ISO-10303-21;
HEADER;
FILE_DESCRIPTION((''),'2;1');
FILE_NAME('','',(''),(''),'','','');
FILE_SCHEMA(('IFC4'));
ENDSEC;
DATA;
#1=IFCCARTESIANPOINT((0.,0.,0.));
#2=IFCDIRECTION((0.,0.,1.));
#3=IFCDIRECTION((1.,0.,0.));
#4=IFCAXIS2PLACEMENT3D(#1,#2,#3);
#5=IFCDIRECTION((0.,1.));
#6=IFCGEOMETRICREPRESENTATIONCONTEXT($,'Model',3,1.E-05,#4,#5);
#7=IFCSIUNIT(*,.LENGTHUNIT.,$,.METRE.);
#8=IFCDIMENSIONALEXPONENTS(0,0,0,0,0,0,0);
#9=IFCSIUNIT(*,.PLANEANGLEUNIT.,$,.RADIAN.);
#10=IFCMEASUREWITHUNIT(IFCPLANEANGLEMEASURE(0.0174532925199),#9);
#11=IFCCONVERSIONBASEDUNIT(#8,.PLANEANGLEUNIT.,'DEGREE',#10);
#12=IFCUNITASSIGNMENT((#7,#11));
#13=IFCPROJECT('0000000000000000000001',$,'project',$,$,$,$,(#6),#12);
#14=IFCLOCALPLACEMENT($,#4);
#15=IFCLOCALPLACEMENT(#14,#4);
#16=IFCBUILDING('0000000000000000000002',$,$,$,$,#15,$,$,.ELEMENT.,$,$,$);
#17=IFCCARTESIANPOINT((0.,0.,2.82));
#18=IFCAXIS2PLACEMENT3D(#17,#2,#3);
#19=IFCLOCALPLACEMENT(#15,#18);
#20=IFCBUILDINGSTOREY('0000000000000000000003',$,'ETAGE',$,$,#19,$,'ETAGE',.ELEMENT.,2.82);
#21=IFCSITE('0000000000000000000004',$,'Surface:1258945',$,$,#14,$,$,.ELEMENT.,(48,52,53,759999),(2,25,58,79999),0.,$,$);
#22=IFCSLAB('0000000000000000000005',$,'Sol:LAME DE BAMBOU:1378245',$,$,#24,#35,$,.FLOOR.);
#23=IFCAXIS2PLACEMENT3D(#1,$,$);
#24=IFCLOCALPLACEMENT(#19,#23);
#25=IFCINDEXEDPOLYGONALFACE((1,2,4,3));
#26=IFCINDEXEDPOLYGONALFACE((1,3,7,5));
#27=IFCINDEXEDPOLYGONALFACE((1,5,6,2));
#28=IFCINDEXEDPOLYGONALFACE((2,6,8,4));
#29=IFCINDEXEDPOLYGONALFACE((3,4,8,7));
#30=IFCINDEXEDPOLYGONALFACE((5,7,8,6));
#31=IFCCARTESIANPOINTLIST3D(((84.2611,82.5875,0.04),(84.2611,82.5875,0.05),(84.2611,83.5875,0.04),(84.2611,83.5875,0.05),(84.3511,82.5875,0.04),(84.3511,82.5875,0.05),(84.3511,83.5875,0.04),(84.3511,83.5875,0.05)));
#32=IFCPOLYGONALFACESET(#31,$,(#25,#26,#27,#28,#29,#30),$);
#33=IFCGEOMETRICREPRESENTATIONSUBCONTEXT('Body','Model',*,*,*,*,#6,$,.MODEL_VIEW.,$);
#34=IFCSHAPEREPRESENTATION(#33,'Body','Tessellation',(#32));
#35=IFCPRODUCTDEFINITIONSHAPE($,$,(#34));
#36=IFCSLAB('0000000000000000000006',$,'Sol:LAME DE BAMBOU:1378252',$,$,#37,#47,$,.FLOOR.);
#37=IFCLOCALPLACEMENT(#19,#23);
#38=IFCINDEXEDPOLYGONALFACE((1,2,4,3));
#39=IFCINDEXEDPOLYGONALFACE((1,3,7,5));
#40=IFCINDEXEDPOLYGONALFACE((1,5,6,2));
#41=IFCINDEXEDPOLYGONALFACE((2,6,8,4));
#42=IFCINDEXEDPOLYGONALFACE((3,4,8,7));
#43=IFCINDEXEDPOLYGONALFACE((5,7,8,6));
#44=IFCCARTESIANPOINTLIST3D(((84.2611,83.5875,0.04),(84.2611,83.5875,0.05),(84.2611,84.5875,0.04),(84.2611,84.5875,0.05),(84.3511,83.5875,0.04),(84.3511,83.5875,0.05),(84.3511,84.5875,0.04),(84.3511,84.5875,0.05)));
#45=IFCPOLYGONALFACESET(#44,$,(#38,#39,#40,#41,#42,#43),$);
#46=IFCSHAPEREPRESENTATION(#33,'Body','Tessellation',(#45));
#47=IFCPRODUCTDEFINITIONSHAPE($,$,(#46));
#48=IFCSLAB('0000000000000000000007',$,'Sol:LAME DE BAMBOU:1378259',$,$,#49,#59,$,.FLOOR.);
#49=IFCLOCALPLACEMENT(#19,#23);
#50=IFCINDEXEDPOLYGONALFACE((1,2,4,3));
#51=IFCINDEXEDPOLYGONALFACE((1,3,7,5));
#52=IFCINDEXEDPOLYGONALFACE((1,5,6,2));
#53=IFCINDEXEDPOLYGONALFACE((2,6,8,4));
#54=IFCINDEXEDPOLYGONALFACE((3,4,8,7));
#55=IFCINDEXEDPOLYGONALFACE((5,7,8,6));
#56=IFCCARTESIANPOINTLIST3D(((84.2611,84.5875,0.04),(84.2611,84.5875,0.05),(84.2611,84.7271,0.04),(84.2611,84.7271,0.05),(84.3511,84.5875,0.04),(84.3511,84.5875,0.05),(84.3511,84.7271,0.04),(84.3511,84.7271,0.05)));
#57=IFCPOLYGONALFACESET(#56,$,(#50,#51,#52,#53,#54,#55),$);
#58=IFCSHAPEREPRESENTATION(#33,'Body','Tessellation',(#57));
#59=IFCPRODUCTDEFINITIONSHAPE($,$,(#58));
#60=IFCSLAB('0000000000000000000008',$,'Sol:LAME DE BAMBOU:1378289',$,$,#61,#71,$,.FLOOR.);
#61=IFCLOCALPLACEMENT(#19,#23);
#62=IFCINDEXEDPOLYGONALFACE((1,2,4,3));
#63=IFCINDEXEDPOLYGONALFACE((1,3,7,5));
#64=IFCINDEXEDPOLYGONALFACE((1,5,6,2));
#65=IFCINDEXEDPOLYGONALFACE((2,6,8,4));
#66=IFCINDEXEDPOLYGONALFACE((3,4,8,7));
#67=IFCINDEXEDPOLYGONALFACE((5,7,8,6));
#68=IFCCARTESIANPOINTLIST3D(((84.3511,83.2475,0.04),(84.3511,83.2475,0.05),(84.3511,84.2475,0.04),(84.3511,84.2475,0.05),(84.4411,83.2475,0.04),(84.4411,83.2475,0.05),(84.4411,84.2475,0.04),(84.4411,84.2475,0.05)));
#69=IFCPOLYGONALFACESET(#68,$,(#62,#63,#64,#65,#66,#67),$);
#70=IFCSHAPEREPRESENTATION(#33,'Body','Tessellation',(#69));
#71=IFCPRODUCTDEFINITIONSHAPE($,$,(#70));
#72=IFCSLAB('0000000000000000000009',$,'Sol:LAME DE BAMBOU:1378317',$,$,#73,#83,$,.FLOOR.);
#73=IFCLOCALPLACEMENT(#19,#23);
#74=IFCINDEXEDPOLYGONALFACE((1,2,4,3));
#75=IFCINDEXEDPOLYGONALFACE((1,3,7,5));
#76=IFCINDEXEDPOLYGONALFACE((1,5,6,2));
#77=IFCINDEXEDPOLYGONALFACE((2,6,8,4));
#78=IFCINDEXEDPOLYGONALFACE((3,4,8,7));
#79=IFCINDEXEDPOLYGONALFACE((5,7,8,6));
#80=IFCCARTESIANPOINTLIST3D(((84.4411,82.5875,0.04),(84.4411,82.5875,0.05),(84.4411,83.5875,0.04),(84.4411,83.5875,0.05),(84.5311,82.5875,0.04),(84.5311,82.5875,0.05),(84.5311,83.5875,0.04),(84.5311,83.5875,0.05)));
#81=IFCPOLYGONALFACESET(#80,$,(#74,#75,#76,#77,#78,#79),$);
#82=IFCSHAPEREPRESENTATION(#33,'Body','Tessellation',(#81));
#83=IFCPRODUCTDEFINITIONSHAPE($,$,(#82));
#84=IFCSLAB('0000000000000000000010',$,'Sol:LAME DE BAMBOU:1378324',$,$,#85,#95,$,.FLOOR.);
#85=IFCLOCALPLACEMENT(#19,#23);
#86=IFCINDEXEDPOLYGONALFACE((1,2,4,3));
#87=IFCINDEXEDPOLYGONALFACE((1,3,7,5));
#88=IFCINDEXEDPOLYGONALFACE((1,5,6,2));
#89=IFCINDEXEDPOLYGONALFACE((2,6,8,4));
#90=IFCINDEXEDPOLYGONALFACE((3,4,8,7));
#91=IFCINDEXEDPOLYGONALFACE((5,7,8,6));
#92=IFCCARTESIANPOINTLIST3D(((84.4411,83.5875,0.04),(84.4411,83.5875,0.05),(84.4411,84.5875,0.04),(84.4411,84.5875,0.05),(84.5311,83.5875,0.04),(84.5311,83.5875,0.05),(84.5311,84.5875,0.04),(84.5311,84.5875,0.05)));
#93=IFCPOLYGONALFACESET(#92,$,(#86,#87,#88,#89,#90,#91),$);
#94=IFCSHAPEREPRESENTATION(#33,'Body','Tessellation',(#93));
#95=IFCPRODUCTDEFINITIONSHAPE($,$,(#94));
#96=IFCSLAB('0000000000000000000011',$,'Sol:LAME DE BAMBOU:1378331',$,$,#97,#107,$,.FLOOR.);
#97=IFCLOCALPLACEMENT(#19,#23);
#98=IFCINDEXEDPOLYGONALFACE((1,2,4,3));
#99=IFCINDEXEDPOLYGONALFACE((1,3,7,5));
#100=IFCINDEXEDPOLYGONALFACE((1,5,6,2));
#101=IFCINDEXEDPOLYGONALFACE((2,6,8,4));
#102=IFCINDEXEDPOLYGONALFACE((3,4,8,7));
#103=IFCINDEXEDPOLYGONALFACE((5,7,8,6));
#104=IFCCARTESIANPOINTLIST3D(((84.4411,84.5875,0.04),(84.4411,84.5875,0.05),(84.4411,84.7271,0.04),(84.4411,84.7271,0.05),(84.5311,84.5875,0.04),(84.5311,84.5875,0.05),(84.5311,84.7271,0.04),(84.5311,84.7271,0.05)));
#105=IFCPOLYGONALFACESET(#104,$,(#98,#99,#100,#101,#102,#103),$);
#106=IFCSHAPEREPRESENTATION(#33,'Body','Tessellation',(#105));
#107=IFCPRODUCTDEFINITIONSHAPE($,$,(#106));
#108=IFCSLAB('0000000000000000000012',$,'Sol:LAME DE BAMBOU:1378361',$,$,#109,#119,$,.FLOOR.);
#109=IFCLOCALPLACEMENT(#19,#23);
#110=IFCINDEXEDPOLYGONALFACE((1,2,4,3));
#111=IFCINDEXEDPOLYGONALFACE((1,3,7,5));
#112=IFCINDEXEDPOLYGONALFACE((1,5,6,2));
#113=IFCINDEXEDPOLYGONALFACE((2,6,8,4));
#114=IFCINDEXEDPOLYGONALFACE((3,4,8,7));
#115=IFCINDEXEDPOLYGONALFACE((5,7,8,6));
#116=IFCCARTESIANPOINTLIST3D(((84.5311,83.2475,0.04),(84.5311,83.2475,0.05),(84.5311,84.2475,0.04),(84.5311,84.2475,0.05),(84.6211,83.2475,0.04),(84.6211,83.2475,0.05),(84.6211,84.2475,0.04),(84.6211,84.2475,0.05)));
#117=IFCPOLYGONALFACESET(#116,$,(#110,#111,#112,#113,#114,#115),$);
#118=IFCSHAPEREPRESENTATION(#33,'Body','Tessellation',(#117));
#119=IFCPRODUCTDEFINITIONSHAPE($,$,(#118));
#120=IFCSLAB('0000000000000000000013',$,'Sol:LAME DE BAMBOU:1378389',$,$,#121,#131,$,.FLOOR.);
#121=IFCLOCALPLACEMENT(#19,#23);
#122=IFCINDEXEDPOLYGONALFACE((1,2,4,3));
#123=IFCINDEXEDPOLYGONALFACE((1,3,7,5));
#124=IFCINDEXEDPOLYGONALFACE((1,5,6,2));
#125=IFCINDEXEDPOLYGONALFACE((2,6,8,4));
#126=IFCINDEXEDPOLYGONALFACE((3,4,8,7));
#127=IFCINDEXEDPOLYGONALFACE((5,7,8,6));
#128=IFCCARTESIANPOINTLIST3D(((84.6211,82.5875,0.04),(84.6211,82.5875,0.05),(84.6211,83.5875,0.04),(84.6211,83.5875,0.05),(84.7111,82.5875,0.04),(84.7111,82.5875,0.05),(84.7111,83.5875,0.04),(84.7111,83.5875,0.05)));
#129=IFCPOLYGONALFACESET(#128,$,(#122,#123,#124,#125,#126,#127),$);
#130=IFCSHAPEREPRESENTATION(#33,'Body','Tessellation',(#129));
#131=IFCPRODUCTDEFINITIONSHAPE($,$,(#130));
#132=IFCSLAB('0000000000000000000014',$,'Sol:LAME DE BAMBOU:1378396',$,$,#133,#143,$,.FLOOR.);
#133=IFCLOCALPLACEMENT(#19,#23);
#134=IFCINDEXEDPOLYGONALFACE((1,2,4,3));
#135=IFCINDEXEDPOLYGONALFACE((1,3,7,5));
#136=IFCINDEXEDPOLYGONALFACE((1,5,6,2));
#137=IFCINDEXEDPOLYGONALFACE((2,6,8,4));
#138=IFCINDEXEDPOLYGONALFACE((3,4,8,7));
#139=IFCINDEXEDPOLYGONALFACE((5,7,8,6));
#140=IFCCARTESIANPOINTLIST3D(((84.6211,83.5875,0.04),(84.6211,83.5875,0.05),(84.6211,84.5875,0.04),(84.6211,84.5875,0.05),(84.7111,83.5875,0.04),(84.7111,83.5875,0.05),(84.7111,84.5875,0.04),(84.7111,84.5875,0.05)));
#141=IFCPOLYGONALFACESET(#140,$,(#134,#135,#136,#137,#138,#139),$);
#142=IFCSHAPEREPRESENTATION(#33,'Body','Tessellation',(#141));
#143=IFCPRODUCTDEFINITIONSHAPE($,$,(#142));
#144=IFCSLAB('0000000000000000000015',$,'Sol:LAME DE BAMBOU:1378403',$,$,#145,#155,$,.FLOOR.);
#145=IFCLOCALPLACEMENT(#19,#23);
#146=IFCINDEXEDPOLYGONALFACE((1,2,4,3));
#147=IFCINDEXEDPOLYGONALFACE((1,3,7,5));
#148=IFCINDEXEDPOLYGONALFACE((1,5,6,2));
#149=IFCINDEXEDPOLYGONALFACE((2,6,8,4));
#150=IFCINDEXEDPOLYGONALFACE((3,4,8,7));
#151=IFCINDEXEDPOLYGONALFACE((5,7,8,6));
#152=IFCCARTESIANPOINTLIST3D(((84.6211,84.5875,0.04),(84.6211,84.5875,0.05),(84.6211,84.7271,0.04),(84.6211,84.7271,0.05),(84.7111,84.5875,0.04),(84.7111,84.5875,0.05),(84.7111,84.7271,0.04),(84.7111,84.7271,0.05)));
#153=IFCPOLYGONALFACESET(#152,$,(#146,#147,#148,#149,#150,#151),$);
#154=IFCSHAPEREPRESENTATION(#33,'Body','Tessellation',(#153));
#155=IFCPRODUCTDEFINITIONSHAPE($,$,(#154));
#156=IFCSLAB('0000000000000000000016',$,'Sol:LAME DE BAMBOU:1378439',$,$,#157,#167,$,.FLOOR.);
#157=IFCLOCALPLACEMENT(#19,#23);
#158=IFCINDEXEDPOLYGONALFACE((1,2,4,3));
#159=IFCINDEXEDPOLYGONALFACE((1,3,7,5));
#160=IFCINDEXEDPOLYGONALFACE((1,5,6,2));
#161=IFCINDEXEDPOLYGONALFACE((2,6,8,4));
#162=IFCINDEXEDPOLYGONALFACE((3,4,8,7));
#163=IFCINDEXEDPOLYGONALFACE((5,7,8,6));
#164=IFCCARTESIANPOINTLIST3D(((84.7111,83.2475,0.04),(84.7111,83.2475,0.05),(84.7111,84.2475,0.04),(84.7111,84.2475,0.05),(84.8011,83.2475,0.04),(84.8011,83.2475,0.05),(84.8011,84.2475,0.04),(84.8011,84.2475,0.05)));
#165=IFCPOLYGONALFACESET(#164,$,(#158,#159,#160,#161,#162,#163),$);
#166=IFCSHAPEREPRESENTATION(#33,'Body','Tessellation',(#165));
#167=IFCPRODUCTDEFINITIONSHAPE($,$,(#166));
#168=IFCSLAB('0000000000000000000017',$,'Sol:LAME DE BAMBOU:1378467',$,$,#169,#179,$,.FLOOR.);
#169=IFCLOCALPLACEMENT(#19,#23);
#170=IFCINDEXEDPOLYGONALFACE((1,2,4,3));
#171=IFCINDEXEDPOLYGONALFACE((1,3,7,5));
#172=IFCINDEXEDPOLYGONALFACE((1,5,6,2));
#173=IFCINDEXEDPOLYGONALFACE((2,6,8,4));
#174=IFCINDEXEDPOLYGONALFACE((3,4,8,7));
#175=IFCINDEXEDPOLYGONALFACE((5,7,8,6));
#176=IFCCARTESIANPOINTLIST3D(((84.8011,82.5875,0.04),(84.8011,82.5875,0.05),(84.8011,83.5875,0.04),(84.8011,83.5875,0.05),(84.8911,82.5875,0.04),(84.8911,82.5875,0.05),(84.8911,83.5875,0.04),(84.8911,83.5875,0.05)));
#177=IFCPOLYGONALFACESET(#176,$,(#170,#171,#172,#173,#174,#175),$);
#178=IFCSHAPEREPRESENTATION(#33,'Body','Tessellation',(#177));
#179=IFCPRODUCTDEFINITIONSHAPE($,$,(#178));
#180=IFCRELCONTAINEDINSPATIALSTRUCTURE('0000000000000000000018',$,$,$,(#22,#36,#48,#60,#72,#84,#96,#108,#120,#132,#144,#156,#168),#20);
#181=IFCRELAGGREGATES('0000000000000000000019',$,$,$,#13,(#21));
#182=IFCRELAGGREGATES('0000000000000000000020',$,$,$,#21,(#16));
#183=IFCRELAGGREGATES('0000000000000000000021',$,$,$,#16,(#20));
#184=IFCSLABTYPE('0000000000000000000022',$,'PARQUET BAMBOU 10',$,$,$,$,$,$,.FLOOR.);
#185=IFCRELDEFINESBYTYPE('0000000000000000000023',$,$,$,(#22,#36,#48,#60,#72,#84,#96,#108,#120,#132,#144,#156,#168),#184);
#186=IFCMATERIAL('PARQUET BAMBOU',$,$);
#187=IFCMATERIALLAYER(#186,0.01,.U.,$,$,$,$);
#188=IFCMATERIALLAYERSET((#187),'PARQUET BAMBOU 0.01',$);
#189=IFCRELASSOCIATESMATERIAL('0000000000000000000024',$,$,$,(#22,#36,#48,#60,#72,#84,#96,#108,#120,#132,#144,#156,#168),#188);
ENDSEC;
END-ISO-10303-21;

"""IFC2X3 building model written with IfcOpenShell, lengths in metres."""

from ifc_helpers import new_model, entity, si_unit, converted_unit, direction, frame, origin_with_axes, place, context, subcontext, project, spatial, polyline, outline, extrude, material, layer, layer_set, layer_usage, type_object, element, save


model = new_model("IFC2X3")

# Units and contexts
model_context = context("Model", 3, precision=1e-05, world=origin_with_axes(), true_north=direction((0.0, 1.0)))
body_context = subcontext(model_context, "Body", "Model", "MODEL_VIEW")
ifc_project = project(units=[si_unit("LENGTHUNIT", "METRE"), converted_unit("PLANEANGLEUNIT", "DEGREE", entity("IfcPlaneAngleMeasure", 0.0174532925199), si_unit("PLANEANGLEUNIT", "RADIAN"), dimensions=[0, 0, 0, 0, 0, 0, 0])], contexts=[model_context])

# Site, building, storey
site_placement = place(None, origin_with_axes())
site = spatial("IfcSite", under=ifc_project, at=site_placement, Name="Surface:1258945", CompositionType="ELEMENT", RefLatitude=(48, 52, 53, 759999), RefLongitude=(2, 25, 58, 79999), RefElevation=0.0)
building_placement = place(site_placement, origin_with_axes())
building = spatial("IfcBuilding", under=site, at=building_placement, CompositionType="ELEMENT")
storey_placement = place(building_placement, frame((0.0, 0.0, 2.82), z_axis=(0.0, 0.0, 1.0), x_axis=(1.0, 0.0, 0.0)))
storey = spatial("IfcBuildingStorey", under=building, at=storey_placement, Name="ETAGE", LongName="ETAGE", CompositionType="ELEMENT", Elevation=2.82)

# Slabs
ifc_material = material(Name="PARQUET BAMBOU")
ifc_layer = layer(ifc_material, 0.01, ventilated="UNKNOWN")
ifc_layer_set = layer_set([ifc_layer], Name="PARQUET BAMBOU 0.01")
ifc_layer_usage_1 = layer_usage(ifc_layer_set, "AXIS3", "NEGATIVE", 0.01)
slab_type = type_object("IfcSlabType", Name="PARQUET BAMBOU 10", PredefinedType="FLOOR")
slab_1_placement = place(storey_placement, frame((84.2611, 83.5875, 0.05), z_axis=(0.0, 0.0, 1.0), x_axis=(1.0, 0.0, 0.0)))
element("IfcSlab", 1, at=slab_1_placement, inside=storey, type_object=slab_type, material=ifc_layer_usage_1, Name="Sol:LAME DE BAMBOU:1378245", PredefinedType="FLOOR", context=body_context, shape_type="SweptSolid", body=[
    extrude(outline(polyline([(0.0, 0.0), (0.0, -1.0), (0.09, -1.0), (0.09, 0.0), (0.0, 0.0)])), frame((0.0, 0.0, -0.01), z_axis=(0.0, 0.0, 1.0), x_axis=(1.0, 0.0, 0.0)), (0.0, 0.0, 1.0), 0.01),
])
ifc_layer_usage_2 = layer_usage(ifc_layer_set, "AXIS3", "NEGATIVE", 0.01)
slab_2_placement = place(storey_placement, frame((84.2611, 84.5875, 0.05), z_axis=(0.0, 0.0, 1.0), x_axis=(1.0, 0.0, 0.0)))
element("IfcSlab", 2, at=slab_2_placement, inside=storey, type_object=slab_type, material=ifc_layer_usage_2, Name="Sol:LAME DE BAMBOU:1378252", PredefinedType="FLOOR", context=body_context, shape_type="SweptSolid", body=[
    extrude(outline(polyline([(0.0, 0.0), (0.0, -1.0), (0.09, -1.0), (0.09, 0.0), (0.0, 0.0)])), frame((0.0, 0.0, -0.01), z_axis=(0.0, 0.0, 1.0), x_axis=(1.0, 0.0, 0.0)), (0.0, 0.0, 1.0), 0.01),
])
ifc_layer_usage_3 = layer_usage(ifc_layer_set, "AXIS3", "NEGATIVE", 0.01)
slab_3_placement = place(storey_placement, frame((84.2611, 84.7271, 0.05), z_axis=(0.0, 0.0, 1.0), x_axis=(1.0, 0.0, 0.0)))
element("IfcSlab", 3, at=slab_3_placement, inside=storey, type_object=slab_type, material=ifc_layer_usage_3, Name="Sol:LAME DE BAMBOU:1378259", PredefinedType="FLOOR", context=body_context, shape_type="SweptSolid", body=[
    extrude(outline(polyline([(0.0, 0.0), (0.0, -0.1396), (0.09, -0.1396), (0.09, 0.0), (0.0, 0.0)])), frame((0.0, 0.0, -0.01), z_axis=(0.0, 0.0, 1.0), x_axis=(1.0, 0.0, 0.0)), (0.0, 0.0, 1.0), 0.01),
])
ifc_layer_usage_4 = layer_usage(ifc_layer_set, "AXIS3", "NEGATIVE", 0.01)
slab_4_placement = place(storey_placement, frame((84.3511, 84.2475, 0.05), z_axis=(0.0, 0.0, 1.0), x_axis=(1.0, 0.0, 0.0)))
element("IfcSlab", 4, at=slab_4_placement, inside=storey, type_object=slab_type, material=ifc_layer_usage_4, Name="Sol:LAME DE BAMBOU:1378289", PredefinedType="FLOOR", context=body_context, shape_type="SweptSolid", body=[
    extrude(outline(polyline([(0.0, 0.0), (0.0, -1.0), (0.09, -1.0), (0.09, 0.0), (0.0, 0.0)])), frame((0.0, 0.0, -0.01), z_axis=(0.0, 0.0, 1.0), x_axis=(1.0, 0.0, 0.0)), (0.0, 0.0, 1.0), 0.01),
])
ifc_layer_usage_5 = layer_usage(ifc_layer_set, "AXIS3", "NEGATIVE", 0.01)
slab_5_placement = place(storey_placement, frame((84.4411, 83.5875, 0.05), z_axis=(0.0, 0.0, 1.0), x_axis=(1.0, 0.0, 0.0)))
element("IfcSlab", 5, at=slab_5_placement, inside=storey, type_object=slab_type, material=ifc_layer_usage_5, Name="Sol:LAME DE BAMBOU:1378317", PredefinedType="FLOOR", context=body_context, shape_type="SweptSolid", body=[
    extrude(outline(polyline([(0.0, 0.0), (0.0, -1.0), (0.09, -1.0), (0.09, 0.0), (0.0, 0.0)])), frame((0.0, 0.0, -0.01), z_axis=(0.0, 0.0, 1.0), x_axis=(1.0, 0.0, 0.0)), (0.0, 0.0, 1.0), 0.01),
])
ifc_layer_usage_6 = layer_usage(ifc_layer_set, "AXIS3", "NEGATIVE", 0.01)
slab_6_placement = place(storey_placement, frame((84.4411, 84.5875, 0.05), z_axis=(0.0, 0.0, 1.0), x_axis=(1.0, 0.0, 0.0)))
element("IfcSlab", 6, at=slab_6_placement, inside=storey, type_object=slab_type, material=ifc_layer_usage_6, Name="Sol:LAME DE BAMBOU:1378324", PredefinedType="FLOOR", context=body_context, shape_type="SweptSolid", body=[
    extrude(outline(polyline([(0.0, 0.0), (0.0, -1.0), (0.09, -1.0), (0.09, 0.0), (0.0, 0.0)])), frame((0.0, 0.0, -0.01), z_axis=(0.0, 0.0, 1.0), x_axis=(1.0, 0.0, 0.0)), (0.0, 0.0, 1.0), 0.01),
])
ifc_layer_usage_7 = layer_usage(ifc_layer_set, "AXIS3", "NEGATIVE", 0.01)
slab_7_placement = place(storey_placement, frame((84.4411, 84.7271, 0.05), z_axis=(0.0, 0.0, 1.0), x_axis=(1.0, 0.0, 0.0)))
element("IfcSlab", 7, at=slab_7_placement, inside=storey, type_object=slab_type, material=ifc_layer_usage_7, Name="Sol:LAME DE BAMBOU:1378331", PredefinedType="FLOOR", context=body_context, shape_type="SweptSolid", body=[
    extrude(outline(polyline([(0.0, 0.0), (0.0, -0.1396), (0.09, -0.1396), (0.09, 0.0), (0.0, 0.0)])), frame((0.0, 0.0, -0.01), z_axis=(0.0, 0.0, 1.0), x_axis=(1.0, 0.0, 0.0)), (0.0, 0.0, 1.0), 0.01),
])
ifc_layer_usage_8 = layer_usage(ifc_layer_set, "AXIS3", "NEGATIVE", 0.01)
slab_8_placement = place(storey_placement, frame((84.5311, 84.2475, 0.05), z_axis=(0.0, 0.0, 1.0), x_axis=(1.0, 0.0, 0.0)))
element("IfcSlab", 8, at=slab_8_placement, inside=storey, type_object=slab_type, material=ifc_layer_usage_8, Name="Sol:LAME DE BAMBOU:1378361", PredefinedType="FLOOR", context=body_context, shape_type="SweptSolid", body=[
    extrude(outline(polyline([(0.0, 0.0), (0.0, -1.0), (0.09, -1.0), (0.09, 0.0), (0.0, 0.0)])), frame((0.0, 0.0, -0.01), z_axis=(0.0, 0.0, 1.0), x_axis=(1.0, 0.0, 0.0)), (0.0, 0.0, 1.0), 0.01),
])
ifc_layer_usage_9 = layer_usage(ifc_layer_set, "AXIS3", "NEGATIVE", 0.01)
slab_9_placement = place(storey_placement, frame((84.6211, 83.5875, 0.05), z_axis=(0.0, 0.0, 1.0), x_axis=(1.0, 0.0, 0.0)))
element("IfcSlab", 9, at=slab_9_placement, inside=storey, type_object=slab_type, material=ifc_layer_usage_9, Name="Sol:LAME DE BAMBOU:1378389", PredefinedType="FLOOR", context=body_context, shape_type="SweptSolid", body=[
    extrude(outline(polyline([(0.0, 0.0), (0.0, -1.0), (0.09, -1.0), (0.09, 0.0), (0.0, 0.0)])), frame((0.0, 0.0, -0.01), z_axis=(0.0, 0.0, 1.0), x_axis=(1.0, 0.0, 0.0)), (0.0, 0.0, 1.0), 0.01),
])
ifc_layer_usage_10 = layer_usage(ifc_layer_set, "AXIS3", "NEGATIVE", 0.01)
slab_10_placement = place(storey_placement, frame((84.6211, 84.5875, 0.05), z_axis=(0.0, 0.0, 1.0), x_axis=(1.0, 0.0, 0.0)))
element("IfcSlab", 10, at=slab_10_placement, inside=storey, type_object=slab_type, material=ifc_layer_usage_10, Name="Sol:LAME DE BAMBOU:1378396", PredefinedType="FLOOR", context=body_context, shape_type="SweptSolid", body=[
    extrude(outline(polyline([(0.0, 0.0), (0.0, -1.0), (0.09, -1.0), (0.09, 0.0), (0.0, 0.0)])), frame((0.0, 0.0, -0.01), z_axis=(0.0, 0.0, 1.0), x_axis=(1.0, 0.0, 0.0)), (0.0, 0.0, 1.0), 0.01),
])
ifc_layer_usage_11 = layer_usage(ifc_layer_set, "AXIS3", "NEGATIVE", 0.01)
slab_11_placement = place(storey_placement, frame((84.6211, 84.7271, 0.05), z_axis=(0.0, 0.0, 1.0), x_axis=(1.0, 0.0, 0.0)))
element("IfcSlab", 11, at=slab_11_placement, inside=storey, type_object=slab_type, material=ifc_layer_usage_11, Name="Sol:LAME DE BAMBOU:1378403", PredefinedType="FLOOR", context=body_context, shape_type="SweptSolid", body=[
    extrude(outline(polyline([(0.0, 0.0), (0.0, -0.1396), (0.09, -0.1396), (0.09, 0.0), (0.0, 0.0)])), frame((0.0, 0.0, -0.01), z_axis=(0.0, 0.0, 1.0), x_axis=(1.0, 0.0, 0.0)), (0.0, 0.0, 1.0), 0.01),
])
ifc_layer_usage_12 = layer_usage(ifc_layer_set, "AXIS3", "NEGATIVE", 0.01)
slab_12_placement = place(storey_placement, frame((84.7111, 84.2475, 0.05), z_axis=(0.0, 0.0, 1.0), x_axis=(1.0, 0.0, 0.0)))
element("IfcSlab", 12, at=slab_12_placement, inside=storey, type_object=slab_type, material=ifc_layer_usage_12, Name="Sol:LAME DE BAMBOU:1378439", PredefinedType="FLOOR", context=body_context, shape_type="SweptSolid", body=[
    extrude(outline(polyline([(0.0, 0.0), (0.0, -1.0), (0.09, -1.0), (0.09, 0.0), (0.0, 0.0)])), frame((0.0, 0.0, -0.01), z_axis=(0.0, 0.0, 1.0), x_axis=(1.0, 0.0, 0.0)), (0.0, 0.0, 1.0), 0.01),
])
ifc_layer_usage_13 = layer_usage(ifc_layer_set, "AXIS3", "NEGATIVE", 0.01)
slab_13_placement = place(storey_placement, frame((84.8011, 83.5875, 0.05), z_axis=(0.0, 0.0, 1.0), x_axis=(1.0, 0.0, 0.0)))
element("IfcSlab", 13, at=slab_13_placement, inside=storey, type_object=slab_type, material=ifc_layer_usage_13, Name="Sol:LAME DE BAMBOU:1378467", PredefinedType="FLOOR", context=body_context, shape_type="SweptSolid", body=[
    extrude(outline(polyline([(0.0, 0.0), (0.0, -1.0), (0.09, -1.0), (0.09, 0.0), (0.0, 0.0)])), frame((0.0, 0.0, -0.01), z_axis=(0.0, 0.0, 1.0), x_axis=(1.0, 0.0, 0.0)), (0.0, 0.0, 1.0), 0.01),
])

save(model, "model.ifc")
